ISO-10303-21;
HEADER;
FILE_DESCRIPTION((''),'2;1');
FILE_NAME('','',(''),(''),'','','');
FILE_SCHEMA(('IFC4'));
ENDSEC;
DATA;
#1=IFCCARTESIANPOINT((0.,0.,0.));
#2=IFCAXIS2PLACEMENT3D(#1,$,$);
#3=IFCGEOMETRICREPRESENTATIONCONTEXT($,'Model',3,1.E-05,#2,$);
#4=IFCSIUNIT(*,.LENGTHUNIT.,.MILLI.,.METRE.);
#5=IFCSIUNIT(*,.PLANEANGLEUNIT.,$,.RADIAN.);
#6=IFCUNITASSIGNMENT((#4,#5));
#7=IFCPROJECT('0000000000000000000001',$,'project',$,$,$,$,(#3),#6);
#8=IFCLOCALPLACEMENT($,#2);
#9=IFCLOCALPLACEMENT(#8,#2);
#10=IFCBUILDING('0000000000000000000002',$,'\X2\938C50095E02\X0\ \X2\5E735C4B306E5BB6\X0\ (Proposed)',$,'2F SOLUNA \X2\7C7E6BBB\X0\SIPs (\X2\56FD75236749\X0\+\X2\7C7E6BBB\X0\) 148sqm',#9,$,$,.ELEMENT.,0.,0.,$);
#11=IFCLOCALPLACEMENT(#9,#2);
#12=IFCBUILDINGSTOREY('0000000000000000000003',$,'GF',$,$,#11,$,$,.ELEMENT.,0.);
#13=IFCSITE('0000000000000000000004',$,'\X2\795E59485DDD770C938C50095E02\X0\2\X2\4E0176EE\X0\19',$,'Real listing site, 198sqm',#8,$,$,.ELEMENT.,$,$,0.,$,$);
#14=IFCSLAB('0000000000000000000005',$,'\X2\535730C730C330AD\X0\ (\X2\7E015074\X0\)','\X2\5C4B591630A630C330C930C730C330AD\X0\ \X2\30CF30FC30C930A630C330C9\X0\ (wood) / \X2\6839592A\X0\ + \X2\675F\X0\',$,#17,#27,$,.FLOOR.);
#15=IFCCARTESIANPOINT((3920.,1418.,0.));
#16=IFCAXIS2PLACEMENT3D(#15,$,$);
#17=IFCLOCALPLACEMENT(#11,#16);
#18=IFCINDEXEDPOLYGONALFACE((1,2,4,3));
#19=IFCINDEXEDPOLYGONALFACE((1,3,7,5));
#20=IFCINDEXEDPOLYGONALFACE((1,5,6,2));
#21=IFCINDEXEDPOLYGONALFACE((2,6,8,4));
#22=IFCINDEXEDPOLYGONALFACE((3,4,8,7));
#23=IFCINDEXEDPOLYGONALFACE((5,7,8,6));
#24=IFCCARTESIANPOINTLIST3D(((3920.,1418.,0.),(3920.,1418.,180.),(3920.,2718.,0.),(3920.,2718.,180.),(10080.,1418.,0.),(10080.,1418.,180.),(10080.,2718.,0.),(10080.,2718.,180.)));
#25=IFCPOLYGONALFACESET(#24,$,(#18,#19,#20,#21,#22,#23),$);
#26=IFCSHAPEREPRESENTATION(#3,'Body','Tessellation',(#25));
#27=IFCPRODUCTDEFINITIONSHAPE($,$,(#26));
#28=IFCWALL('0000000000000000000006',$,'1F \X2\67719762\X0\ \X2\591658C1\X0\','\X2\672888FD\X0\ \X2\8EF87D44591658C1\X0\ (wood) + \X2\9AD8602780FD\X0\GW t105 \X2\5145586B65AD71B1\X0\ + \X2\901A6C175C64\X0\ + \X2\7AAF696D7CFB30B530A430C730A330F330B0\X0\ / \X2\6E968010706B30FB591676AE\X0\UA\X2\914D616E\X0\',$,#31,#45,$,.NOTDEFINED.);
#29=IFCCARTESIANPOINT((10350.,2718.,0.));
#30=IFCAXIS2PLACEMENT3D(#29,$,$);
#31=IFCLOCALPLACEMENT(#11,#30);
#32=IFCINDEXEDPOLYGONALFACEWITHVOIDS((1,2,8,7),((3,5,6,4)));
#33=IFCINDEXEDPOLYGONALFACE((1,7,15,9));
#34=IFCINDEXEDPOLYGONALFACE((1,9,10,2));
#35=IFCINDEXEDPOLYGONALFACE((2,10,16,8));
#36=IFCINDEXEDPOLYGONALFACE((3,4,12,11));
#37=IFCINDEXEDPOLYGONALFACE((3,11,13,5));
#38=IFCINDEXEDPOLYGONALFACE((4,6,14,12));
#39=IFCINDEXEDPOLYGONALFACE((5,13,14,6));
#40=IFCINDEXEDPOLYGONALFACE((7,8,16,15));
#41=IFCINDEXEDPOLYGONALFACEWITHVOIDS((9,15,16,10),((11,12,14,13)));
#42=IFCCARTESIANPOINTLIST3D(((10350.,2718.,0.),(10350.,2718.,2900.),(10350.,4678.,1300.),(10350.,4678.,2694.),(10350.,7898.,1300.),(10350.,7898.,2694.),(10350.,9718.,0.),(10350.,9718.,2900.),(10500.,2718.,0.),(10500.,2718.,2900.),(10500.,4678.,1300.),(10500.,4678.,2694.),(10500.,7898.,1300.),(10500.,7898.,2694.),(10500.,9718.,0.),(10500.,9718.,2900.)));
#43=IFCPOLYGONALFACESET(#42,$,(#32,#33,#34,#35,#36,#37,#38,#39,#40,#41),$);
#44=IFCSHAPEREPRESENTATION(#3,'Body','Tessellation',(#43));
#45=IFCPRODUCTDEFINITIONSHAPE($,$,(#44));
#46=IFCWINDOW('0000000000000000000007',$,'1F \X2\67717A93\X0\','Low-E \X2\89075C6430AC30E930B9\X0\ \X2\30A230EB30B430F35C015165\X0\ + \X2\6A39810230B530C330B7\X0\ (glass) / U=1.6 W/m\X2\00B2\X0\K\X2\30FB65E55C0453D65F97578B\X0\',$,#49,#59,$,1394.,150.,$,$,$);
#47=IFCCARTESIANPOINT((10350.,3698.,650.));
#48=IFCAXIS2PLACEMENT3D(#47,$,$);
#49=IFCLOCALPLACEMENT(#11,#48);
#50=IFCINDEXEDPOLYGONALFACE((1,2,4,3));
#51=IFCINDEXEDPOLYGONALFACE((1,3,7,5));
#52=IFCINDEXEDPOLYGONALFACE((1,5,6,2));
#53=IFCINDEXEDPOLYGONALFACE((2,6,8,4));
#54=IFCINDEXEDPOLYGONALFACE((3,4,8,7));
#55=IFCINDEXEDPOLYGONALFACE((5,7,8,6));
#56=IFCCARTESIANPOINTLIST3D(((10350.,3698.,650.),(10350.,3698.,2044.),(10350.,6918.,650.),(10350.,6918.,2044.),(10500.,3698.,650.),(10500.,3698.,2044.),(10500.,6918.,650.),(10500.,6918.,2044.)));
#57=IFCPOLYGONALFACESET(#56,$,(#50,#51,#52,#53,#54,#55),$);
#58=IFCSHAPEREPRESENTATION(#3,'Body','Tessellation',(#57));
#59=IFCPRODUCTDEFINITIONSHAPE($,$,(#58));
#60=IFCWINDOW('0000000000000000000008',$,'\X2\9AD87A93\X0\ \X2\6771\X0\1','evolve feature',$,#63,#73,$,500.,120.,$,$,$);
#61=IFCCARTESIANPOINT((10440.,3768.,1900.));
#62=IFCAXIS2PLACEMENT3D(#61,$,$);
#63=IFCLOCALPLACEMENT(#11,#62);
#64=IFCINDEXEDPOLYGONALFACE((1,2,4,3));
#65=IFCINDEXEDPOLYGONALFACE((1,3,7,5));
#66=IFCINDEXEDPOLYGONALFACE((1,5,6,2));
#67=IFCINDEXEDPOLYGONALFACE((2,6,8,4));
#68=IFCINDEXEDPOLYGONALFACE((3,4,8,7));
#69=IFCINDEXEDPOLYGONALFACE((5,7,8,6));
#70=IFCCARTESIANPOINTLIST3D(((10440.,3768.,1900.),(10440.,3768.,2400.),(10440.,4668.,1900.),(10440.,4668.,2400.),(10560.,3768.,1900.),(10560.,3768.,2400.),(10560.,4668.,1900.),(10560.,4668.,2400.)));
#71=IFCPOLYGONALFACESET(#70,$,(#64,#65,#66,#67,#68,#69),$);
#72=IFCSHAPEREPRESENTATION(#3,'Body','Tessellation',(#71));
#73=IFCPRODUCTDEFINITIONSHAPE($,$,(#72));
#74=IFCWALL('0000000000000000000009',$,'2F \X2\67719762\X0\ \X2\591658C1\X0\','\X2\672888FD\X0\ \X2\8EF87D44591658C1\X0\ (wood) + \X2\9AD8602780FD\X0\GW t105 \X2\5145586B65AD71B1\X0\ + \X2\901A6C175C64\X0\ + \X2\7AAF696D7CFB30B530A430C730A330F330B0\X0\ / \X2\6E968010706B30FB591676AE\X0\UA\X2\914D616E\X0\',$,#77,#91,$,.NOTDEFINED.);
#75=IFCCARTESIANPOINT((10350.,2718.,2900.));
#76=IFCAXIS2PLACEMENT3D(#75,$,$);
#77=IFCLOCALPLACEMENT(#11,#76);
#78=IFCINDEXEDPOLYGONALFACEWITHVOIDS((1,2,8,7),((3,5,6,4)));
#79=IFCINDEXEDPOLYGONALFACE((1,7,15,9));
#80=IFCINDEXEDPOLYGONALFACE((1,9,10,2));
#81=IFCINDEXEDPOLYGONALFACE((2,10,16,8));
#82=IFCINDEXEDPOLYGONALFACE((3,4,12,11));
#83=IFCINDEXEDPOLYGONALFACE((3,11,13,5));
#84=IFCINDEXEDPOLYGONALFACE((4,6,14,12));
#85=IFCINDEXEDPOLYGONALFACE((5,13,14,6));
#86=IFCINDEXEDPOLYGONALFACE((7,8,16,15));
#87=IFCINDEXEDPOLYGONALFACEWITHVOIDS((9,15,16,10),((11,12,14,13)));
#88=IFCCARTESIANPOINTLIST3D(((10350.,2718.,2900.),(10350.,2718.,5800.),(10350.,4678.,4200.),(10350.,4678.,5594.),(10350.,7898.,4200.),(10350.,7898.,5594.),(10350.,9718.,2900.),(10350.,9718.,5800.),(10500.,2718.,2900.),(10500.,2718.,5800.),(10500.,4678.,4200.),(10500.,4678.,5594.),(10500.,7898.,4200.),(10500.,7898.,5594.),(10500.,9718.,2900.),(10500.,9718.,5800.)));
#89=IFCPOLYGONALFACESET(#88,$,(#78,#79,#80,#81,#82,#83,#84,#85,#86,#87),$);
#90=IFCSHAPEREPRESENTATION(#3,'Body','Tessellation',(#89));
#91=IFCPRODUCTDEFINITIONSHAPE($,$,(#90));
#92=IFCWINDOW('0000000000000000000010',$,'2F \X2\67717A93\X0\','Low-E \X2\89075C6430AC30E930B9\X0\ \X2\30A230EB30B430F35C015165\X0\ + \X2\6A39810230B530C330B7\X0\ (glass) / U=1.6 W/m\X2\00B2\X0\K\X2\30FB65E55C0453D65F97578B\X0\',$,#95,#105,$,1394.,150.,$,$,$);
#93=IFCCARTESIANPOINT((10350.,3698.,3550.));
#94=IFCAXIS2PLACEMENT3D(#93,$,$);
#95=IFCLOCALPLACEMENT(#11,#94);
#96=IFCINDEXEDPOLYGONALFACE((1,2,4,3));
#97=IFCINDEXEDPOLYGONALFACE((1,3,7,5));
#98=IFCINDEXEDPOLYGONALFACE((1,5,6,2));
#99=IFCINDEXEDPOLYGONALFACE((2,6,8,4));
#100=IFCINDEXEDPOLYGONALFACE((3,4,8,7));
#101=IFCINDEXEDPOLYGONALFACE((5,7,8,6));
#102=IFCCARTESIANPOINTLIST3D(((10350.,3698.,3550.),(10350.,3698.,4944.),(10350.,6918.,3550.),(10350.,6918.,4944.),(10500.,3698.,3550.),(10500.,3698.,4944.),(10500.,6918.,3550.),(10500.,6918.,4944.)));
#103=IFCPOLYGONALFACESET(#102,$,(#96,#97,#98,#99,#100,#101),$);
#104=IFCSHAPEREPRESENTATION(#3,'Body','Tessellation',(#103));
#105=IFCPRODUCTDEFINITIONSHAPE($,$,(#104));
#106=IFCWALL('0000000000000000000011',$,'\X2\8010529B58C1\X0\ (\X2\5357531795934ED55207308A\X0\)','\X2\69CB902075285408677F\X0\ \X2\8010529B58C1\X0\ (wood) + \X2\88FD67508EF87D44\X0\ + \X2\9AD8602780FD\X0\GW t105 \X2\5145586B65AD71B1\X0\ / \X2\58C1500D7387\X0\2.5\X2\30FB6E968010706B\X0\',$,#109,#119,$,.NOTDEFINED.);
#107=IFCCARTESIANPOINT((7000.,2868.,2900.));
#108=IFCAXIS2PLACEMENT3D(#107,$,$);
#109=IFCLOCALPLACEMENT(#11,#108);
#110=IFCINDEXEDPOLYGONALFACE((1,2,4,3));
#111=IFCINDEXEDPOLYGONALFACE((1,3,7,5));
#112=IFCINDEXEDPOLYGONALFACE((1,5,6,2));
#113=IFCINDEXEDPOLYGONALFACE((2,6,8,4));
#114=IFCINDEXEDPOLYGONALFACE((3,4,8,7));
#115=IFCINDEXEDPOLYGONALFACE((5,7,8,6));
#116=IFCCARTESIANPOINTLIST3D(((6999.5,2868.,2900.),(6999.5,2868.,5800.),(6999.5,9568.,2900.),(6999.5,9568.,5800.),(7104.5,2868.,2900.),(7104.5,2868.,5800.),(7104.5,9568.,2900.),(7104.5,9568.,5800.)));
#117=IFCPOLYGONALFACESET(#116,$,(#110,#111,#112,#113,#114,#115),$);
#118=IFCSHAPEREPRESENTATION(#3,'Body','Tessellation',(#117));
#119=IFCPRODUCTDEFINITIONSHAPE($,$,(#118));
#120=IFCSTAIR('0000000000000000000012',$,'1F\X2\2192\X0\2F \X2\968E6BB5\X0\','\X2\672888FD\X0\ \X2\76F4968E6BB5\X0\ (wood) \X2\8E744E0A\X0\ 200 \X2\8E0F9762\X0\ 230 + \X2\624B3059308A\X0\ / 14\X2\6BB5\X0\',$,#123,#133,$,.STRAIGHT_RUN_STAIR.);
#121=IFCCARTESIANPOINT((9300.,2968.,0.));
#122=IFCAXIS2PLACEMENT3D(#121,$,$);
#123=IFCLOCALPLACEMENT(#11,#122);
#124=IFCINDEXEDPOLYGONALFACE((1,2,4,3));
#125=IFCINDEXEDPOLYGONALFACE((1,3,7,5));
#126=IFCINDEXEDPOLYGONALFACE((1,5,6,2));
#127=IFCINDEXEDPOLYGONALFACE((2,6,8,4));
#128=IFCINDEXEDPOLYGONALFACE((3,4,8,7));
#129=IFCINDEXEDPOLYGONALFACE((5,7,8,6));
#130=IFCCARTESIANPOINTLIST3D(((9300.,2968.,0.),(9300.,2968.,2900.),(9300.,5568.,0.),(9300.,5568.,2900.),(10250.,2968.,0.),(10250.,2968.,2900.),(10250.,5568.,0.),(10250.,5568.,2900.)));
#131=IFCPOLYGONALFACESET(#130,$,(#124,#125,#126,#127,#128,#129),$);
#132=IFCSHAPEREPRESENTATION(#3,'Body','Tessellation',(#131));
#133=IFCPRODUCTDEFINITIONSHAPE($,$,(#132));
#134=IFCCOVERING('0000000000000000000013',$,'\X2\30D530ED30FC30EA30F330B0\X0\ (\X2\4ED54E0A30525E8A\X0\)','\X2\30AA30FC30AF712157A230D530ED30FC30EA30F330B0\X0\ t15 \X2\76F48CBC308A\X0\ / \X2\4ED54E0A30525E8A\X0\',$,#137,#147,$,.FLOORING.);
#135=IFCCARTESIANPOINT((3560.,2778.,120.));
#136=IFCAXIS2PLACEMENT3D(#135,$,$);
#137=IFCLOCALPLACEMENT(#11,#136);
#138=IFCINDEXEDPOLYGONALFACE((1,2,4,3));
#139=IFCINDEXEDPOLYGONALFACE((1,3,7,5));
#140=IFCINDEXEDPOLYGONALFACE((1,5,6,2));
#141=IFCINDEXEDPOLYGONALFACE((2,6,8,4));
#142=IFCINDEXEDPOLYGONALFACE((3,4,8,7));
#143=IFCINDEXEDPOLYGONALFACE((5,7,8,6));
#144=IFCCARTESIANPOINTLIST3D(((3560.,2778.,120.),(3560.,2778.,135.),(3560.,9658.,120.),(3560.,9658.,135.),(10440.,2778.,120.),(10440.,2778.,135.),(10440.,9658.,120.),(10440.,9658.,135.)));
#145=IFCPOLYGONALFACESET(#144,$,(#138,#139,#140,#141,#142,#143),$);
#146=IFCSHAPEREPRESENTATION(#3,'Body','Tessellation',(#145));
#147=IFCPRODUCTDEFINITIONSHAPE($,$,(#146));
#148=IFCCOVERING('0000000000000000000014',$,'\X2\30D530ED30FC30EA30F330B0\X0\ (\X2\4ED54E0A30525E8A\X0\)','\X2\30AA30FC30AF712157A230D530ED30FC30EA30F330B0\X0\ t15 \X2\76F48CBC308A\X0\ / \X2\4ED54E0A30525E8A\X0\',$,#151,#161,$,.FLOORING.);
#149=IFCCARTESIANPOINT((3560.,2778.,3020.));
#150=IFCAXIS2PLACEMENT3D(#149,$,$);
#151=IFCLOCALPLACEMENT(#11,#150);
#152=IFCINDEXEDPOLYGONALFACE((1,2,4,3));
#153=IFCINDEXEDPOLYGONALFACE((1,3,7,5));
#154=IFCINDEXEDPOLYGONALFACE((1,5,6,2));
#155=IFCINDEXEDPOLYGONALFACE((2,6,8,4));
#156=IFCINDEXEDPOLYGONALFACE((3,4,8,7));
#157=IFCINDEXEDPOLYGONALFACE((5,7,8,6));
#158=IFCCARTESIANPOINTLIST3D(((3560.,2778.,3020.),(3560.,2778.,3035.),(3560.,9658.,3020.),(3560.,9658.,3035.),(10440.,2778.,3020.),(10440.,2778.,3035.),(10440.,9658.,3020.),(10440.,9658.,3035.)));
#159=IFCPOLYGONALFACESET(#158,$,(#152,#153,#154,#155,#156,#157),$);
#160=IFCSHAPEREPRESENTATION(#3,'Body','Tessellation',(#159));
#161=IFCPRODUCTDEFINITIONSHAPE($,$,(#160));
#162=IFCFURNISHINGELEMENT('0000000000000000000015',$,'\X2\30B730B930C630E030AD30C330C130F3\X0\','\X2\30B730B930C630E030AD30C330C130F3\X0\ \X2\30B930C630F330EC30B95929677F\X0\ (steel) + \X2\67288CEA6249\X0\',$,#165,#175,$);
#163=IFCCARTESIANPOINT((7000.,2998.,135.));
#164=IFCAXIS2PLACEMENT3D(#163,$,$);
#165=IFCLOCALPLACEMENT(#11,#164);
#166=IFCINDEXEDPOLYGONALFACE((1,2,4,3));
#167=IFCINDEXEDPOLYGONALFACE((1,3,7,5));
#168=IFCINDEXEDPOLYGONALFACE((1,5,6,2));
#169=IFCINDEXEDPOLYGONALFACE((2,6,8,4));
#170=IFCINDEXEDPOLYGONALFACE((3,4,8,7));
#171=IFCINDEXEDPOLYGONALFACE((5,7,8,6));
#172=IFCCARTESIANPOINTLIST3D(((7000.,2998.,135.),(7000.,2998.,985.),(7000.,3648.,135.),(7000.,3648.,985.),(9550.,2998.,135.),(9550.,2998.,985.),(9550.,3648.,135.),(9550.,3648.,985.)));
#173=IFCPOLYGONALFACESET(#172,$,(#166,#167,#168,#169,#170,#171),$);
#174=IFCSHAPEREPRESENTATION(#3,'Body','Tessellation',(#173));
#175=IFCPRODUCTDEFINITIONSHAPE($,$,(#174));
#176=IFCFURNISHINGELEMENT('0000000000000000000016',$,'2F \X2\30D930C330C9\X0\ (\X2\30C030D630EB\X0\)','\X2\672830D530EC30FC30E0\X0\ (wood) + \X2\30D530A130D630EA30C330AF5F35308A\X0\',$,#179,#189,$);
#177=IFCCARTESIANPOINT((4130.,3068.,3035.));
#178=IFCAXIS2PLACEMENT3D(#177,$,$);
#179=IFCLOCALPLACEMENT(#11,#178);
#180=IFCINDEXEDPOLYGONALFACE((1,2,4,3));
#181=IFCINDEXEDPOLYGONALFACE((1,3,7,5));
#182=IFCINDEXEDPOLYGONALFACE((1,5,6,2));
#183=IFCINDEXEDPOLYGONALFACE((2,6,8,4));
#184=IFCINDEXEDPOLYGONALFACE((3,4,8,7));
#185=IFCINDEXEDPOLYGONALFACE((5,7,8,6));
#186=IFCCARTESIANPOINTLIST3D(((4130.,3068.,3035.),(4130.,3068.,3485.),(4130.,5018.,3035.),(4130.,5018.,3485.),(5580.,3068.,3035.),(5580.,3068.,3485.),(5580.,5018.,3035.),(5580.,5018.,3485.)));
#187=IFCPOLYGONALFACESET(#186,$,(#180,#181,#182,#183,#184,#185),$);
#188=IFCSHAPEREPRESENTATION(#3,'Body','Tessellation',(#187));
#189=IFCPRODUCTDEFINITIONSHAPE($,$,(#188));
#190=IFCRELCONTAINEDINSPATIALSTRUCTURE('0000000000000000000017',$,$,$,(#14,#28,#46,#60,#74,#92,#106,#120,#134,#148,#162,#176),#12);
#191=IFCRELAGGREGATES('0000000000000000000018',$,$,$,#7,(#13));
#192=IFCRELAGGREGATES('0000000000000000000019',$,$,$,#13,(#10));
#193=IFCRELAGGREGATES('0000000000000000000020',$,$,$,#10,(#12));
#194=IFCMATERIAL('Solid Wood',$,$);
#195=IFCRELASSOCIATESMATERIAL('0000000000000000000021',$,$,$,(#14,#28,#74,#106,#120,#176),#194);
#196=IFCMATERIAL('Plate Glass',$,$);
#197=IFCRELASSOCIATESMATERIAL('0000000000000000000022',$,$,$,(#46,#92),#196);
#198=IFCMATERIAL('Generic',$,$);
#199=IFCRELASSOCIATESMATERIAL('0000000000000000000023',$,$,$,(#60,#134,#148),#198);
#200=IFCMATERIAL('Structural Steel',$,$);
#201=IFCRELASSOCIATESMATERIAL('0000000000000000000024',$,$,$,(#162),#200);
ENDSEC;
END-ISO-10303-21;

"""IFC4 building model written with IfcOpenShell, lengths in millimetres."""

from ifc_helpers import new_model, si_unit, frame, frame_2d, origin, place, context, project, spatial, rectangle, extrude, material, element, fill, save


model = new_model("IFC4")

# Units and contexts
model_context = context("Model", 3, precision=1e-05, world=origin())
ifc_project = project(units=[si_unit("LENGTHUNIT", "METRE", prefix="MILLI"), si_unit("PLANEANGLEUNIT", "RADIAN")], contexts=[model_context])

# Site, building, storey
site_placement = place(None, origin())
site = spatial("IfcSite", under=ifc_project, at=site_placement, Name="神奈川県鎌倉市2丁目19", ObjectType="Real listing site, 198sqm", CompositionType="ELEMENT", RefElevation=0.0)
building_placement = place(site_placement, origin())
building = spatial("IfcBuilding", under=site, at=building_placement, Name="鎌倉市 平屋の家 (Proposed)", ObjectType="2F SOLUNA 籾殻SIPs (国産杉+籾殻) 148sqm", CompositionType="ELEMENT", ElevationOfRefHeight=0.0, ElevationOfTerrain=0.0)
storey_placement = place(building_placement, origin())
storey = spatial("IfcBuildingStorey", under=building, at=storey_placement, Name="GF", CompositionType="ELEMENT", Elevation=0.0)

# Slab
ifc_material_1 = material(Name="Solid Wood")
slab_placement = place(storey_placement, frame((3920.0, 1418.0, 0.0)))
element("IfcSlab", 1, at=slab_placement, inside=storey, material=ifc_material_1, Name="南デッキ (縁側)", Description="屋外ウッドデッキ ハードウッド (wood) / 根太 + 束", PredefinedType="FLOOR", context=model_context, shape_type="SweptSolid", body=[
    extrude(rectangle(XDim=6160.0, YDim=1300.0, at=frame_2d((3080.0, 650.0))), frame((3920.0, 1418.0, 0.0)), (0.0, 0.0, 1.0), 180.0),
])

# Wall, openings, windows
wall_1_placement = place(storey_placement, frame((10350.0, 2718.0, 0.0)))
wall_1 = element("IfcWall", 2, at=wall_1_placement, inside=storey, material=ifc_material_1, Name="1F 東面 外壁", Description="木製 軸組外壁 (wood) + 高性能GW t105 充填断熱 + 通気層 + 窯業系サイディング / 準耐火・外皮UA配慮", PredefinedType="NOTDEFINED", context=model_context, shape_type="SweptSolid", body=[
    extrude(rectangle(XDim=150.0, YDim=7000.0, at=frame_2d((75.0, 3500.0))), frame((10350.0, 2718.0, 0.0)), (0.0, 0.0, 1.0), 2900.0),
])
opening_1_placement = place(storey_placement, frame((10350.0, 3698.0, 650.0)))
opening_1 = element("IfcOpeningElement", 3, at=opening_1_placement, cuts=wall_1, PredefinedType="NOTDEFINED", context=model_context, shape_type="SweptSolid", body=[
    extrude(rectangle(XDim=150.0, YDim=3220.0, at=frame_2d((75.0, 1610.0))), frame((10350.0, 3698.0, 650.0)), (0.0, 0.0, 1.0), 1394.0),
])
opening_2_placement = place(storey_placement, frame((10440.0, 3768.0, 1900.0)))
opening_2 = element("IfcOpeningElement", 4, at=opening_2_placement, cuts=wall_1, PredefinedType="NOTDEFINED", context=model_context, shape_type="SweptSolid", body=[
    extrude(rectangle(XDim=120.0, YDim=900.0, at=frame_2d((60.0, 450.0))), frame((10440.0, 3768.0, 1900.0)), (0.0, 0.0, 1.0), 500.0),
])
ifc_material_2 = material(Name="Plate Glass")
window_1_placement = place(storey_placement, frame((10350.0, 3698.0, 650.0)))
window_1 = element("IfcWindow", 5, at=window_1_placement, inside=storey, material=ifc_material_2, Name="1F 東窓", Description="Low-E 複層ガラス アルゴン封入 + 樹脂サッシ (glass) / U=1.6 W/m²K・日射取得型", OverallHeight=1394.0, OverallWidth=150.0, context=model_context, shape_type="SweptSolid", body=[
    extrude(rectangle(XDim=150.0, YDim=3220.0, at=frame_2d((75.0, 1610.0))), frame((10350.0, 3698.0, 650.0)), (0.0, 0.0, 1.0), 1394.0),
])
fill(opening_1, window_1)
ifc_material_3 = material(Name="Generic")
window_2_placement = place(storey_placement, frame((10440.0, 3768.0, 1900.0)))
window_2 = element("IfcWindow", 6, at=window_2_placement, inside=storey, material=ifc_material_3, Name="高窓 東1", Description="evolve feature", OverallHeight=500.0, OverallWidth=120.0, context=model_context, shape_type="SweptSolid", body=[
    extrude(rectangle(XDim=120.0, YDim=900.0, at=frame_2d((60.0, 450.0))), frame((10440.0, 3768.0, 1900.0)), (0.0, 0.0, 1.0), 500.0),
])
fill(opening_2, window_2)

# Wall, opening, window
wall_2_placement = place(storey_placement, frame((10350.0, 2718.0, 2900.0)))
wall_2 = element("IfcWall", 7, at=wall_2_placement, inside=storey, material=ifc_material_1, Name="2F 東面 外壁", Description="木製 軸組外壁 (wood) + 高性能GW t105 充填断熱 + 通気層 + 窯業系サイディング / 準耐火・外皮UA配慮", PredefinedType="NOTDEFINED", context=model_context, shape_type="SweptSolid", body=[
    extrude(rectangle(XDim=150.0, YDim=7000.0, at=frame_2d((75.0, 3500.0))), frame((10350.0, 2718.0, 2900.0)), (0.0, 0.0, 1.0), 2900.0),
])
opening_3_placement = place(storey_placement, frame((10350.0, 3698.0, 3550.0)))
opening_3 = element("IfcOpeningElement", 8, at=opening_3_placement, cuts=wall_2, PredefinedType="NOTDEFINED", context=model_context, shape_type="SweptSolid", body=[
    extrude(rectangle(XDim=150.0, YDim=3220.0, at=frame_2d((75.0, 1610.0))), frame((10350.0, 3698.0, 3550.0)), (0.0, 0.0, 1.0), 1394.0),
])
window_3_placement = place(storey_placement, frame((10350.0, 3698.0, 3550.0)))
window_3 = element("IfcWindow", 9, at=window_3_placement, inside=storey, material=ifc_material_2, Name="2F 東窓", Description="Low-E 複層ガラス アルゴン封入 + 樹脂サッシ (glass) / U=1.6 W/m²K・日射取得型", OverallHeight=1394.0, OverallWidth=150.0, context=model_context, shape_type="SweptSolid", body=[
    extrude(rectangle(XDim=150.0, YDim=3220.0, at=frame_2d((75.0, 1610.0))), frame((10350.0, 3698.0, 3550.0)), (0.0, 0.0, 1.0), 1394.0),
])
fill(opening_3, window_3)

# Wall
wall_3_placement = place(storey_placement, frame((7000.0, 2868.0, 2900.0)))
element("IfcWall", 10, at=wall_3_placement, inside=storey, material=ifc_material_1, Name="耐力壁 (南北間仕切り)", Description="構造用合板 耐力壁 (wood) + 製材軸組 + 高性能GW t105 充填断熱 / 壁倍率2.5・準耐火", PredefinedType="NOTDEFINED", context=model_context, shape_type="SweptSolid", body=[
    extrude(rectangle(XDim=105.0, YDim=6700.0, at=frame_2d((52.0, 3350.0))), frame((7000.0, 2868.0, 2900.0)), (0.0, 0.0, 1.0), 2900.0),
])

# Stair
stair_placement = place(storey_placement, frame((9300.0, 2968.0, 0.0)))
element("IfcStair", 11, at=stair_placement, inside=storey, material=ifc_material_1, Name="1F→2F 階段", Description="木製 直階段 (wood) 蹴上 200 踏面 230 + 手すり / 14段", PredefinedType="STRAIGHT_RUN_STAIR", context=model_context, shape_type="SweptSolid", body=[
    extrude(rectangle(XDim=950.0, YDim=2600.0, at=frame_2d((475.0, 1300.0))), frame((9300.0, 2968.0, 0.0)), (0.0, 0.0, 1.0), 2900.0),
])

# Coverings
covering_1_placement = place(storey_placement, frame((3560.0, 2778.0, 120.0)))
element("IfcCovering", 12, at=covering_1_placement, inside=storey, material=ifc_material_3, Name="フローリング (仕上げ床)", Description="オーク無垢フローリング t15 直貼り / 仕上げ床", PredefinedType="FLOORING", context=model_context, shape_type="SweptSolid", body=[
    extrude(rectangle(XDim=6880.0, YDim=6880.0, at=frame_2d((3440.0, 3440.0))), frame((3560.0, 2778.0, 120.0)), (0.0, 0.0, 1.0), 15.0),
])
covering_2_placement = place(storey_placement, frame((3560.0, 2778.0, 3020.0)))
element("IfcCovering", 13, at=covering_2_placement, inside=storey, material=ifc_material_3, Name="フローリング (仕上げ床)", Description="オーク無垢フローリング t15 直貼り / 仕上げ床", PredefinedType="FLOORING", context=model_context, shape_type="SweptSolid", body=[
    extrude(rectangle(XDim=6880.0, YDim=6880.0, at=frame_2d((3440.0, 3440.0))), frame((3560.0, 2778.0, 3020.0)), (0.0, 0.0, 1.0), 15.0),
])

# Furnishing elements
ifc_material_4 = material(Name="Structural Steel")
furnishing_1_placement = place(storey_placement, frame((7000.0, 2998.0, 135.0)))
element("IfcFurnishingElement", 14, at=furnishing_1_placement, inside=storey, material=ifc_material_4, Name="システムキッチン", Description="システムキッチン ステンレス天板 (steel) + 木質扉", context=model_context, shape_type="SweptSolid", body=[
    extrude(rectangle(XDim=2550.0, YDim=650.0, at=frame_2d((1275.0, 325.0))), frame((7000.0, 2998.0, 135.0)), (0.0, 0.0, 1.0), 850.0),
])
furnishing_2_placement = place(storey_placement, frame((4130.0, 3068.0, 3035.0)))
element("IfcFurnishingElement", 15, at=furnishing_2_placement, inside=storey, material=ifc_material_1, Name="2F ベッド (ダブル)", Description="木フレーム (wood) + ファブリック張り", context=model_context, shape_type="SweptSolid", body=[
    extrude(rectangle(XDim=1450.0, YDim=1950.0, at=frame_2d((725.0, 975.0))), frame((4130.0, 3068.0, 3035.0)), (0.0, 0.0, 1.0), 450.0),
])

save(model, "model.ifc")
